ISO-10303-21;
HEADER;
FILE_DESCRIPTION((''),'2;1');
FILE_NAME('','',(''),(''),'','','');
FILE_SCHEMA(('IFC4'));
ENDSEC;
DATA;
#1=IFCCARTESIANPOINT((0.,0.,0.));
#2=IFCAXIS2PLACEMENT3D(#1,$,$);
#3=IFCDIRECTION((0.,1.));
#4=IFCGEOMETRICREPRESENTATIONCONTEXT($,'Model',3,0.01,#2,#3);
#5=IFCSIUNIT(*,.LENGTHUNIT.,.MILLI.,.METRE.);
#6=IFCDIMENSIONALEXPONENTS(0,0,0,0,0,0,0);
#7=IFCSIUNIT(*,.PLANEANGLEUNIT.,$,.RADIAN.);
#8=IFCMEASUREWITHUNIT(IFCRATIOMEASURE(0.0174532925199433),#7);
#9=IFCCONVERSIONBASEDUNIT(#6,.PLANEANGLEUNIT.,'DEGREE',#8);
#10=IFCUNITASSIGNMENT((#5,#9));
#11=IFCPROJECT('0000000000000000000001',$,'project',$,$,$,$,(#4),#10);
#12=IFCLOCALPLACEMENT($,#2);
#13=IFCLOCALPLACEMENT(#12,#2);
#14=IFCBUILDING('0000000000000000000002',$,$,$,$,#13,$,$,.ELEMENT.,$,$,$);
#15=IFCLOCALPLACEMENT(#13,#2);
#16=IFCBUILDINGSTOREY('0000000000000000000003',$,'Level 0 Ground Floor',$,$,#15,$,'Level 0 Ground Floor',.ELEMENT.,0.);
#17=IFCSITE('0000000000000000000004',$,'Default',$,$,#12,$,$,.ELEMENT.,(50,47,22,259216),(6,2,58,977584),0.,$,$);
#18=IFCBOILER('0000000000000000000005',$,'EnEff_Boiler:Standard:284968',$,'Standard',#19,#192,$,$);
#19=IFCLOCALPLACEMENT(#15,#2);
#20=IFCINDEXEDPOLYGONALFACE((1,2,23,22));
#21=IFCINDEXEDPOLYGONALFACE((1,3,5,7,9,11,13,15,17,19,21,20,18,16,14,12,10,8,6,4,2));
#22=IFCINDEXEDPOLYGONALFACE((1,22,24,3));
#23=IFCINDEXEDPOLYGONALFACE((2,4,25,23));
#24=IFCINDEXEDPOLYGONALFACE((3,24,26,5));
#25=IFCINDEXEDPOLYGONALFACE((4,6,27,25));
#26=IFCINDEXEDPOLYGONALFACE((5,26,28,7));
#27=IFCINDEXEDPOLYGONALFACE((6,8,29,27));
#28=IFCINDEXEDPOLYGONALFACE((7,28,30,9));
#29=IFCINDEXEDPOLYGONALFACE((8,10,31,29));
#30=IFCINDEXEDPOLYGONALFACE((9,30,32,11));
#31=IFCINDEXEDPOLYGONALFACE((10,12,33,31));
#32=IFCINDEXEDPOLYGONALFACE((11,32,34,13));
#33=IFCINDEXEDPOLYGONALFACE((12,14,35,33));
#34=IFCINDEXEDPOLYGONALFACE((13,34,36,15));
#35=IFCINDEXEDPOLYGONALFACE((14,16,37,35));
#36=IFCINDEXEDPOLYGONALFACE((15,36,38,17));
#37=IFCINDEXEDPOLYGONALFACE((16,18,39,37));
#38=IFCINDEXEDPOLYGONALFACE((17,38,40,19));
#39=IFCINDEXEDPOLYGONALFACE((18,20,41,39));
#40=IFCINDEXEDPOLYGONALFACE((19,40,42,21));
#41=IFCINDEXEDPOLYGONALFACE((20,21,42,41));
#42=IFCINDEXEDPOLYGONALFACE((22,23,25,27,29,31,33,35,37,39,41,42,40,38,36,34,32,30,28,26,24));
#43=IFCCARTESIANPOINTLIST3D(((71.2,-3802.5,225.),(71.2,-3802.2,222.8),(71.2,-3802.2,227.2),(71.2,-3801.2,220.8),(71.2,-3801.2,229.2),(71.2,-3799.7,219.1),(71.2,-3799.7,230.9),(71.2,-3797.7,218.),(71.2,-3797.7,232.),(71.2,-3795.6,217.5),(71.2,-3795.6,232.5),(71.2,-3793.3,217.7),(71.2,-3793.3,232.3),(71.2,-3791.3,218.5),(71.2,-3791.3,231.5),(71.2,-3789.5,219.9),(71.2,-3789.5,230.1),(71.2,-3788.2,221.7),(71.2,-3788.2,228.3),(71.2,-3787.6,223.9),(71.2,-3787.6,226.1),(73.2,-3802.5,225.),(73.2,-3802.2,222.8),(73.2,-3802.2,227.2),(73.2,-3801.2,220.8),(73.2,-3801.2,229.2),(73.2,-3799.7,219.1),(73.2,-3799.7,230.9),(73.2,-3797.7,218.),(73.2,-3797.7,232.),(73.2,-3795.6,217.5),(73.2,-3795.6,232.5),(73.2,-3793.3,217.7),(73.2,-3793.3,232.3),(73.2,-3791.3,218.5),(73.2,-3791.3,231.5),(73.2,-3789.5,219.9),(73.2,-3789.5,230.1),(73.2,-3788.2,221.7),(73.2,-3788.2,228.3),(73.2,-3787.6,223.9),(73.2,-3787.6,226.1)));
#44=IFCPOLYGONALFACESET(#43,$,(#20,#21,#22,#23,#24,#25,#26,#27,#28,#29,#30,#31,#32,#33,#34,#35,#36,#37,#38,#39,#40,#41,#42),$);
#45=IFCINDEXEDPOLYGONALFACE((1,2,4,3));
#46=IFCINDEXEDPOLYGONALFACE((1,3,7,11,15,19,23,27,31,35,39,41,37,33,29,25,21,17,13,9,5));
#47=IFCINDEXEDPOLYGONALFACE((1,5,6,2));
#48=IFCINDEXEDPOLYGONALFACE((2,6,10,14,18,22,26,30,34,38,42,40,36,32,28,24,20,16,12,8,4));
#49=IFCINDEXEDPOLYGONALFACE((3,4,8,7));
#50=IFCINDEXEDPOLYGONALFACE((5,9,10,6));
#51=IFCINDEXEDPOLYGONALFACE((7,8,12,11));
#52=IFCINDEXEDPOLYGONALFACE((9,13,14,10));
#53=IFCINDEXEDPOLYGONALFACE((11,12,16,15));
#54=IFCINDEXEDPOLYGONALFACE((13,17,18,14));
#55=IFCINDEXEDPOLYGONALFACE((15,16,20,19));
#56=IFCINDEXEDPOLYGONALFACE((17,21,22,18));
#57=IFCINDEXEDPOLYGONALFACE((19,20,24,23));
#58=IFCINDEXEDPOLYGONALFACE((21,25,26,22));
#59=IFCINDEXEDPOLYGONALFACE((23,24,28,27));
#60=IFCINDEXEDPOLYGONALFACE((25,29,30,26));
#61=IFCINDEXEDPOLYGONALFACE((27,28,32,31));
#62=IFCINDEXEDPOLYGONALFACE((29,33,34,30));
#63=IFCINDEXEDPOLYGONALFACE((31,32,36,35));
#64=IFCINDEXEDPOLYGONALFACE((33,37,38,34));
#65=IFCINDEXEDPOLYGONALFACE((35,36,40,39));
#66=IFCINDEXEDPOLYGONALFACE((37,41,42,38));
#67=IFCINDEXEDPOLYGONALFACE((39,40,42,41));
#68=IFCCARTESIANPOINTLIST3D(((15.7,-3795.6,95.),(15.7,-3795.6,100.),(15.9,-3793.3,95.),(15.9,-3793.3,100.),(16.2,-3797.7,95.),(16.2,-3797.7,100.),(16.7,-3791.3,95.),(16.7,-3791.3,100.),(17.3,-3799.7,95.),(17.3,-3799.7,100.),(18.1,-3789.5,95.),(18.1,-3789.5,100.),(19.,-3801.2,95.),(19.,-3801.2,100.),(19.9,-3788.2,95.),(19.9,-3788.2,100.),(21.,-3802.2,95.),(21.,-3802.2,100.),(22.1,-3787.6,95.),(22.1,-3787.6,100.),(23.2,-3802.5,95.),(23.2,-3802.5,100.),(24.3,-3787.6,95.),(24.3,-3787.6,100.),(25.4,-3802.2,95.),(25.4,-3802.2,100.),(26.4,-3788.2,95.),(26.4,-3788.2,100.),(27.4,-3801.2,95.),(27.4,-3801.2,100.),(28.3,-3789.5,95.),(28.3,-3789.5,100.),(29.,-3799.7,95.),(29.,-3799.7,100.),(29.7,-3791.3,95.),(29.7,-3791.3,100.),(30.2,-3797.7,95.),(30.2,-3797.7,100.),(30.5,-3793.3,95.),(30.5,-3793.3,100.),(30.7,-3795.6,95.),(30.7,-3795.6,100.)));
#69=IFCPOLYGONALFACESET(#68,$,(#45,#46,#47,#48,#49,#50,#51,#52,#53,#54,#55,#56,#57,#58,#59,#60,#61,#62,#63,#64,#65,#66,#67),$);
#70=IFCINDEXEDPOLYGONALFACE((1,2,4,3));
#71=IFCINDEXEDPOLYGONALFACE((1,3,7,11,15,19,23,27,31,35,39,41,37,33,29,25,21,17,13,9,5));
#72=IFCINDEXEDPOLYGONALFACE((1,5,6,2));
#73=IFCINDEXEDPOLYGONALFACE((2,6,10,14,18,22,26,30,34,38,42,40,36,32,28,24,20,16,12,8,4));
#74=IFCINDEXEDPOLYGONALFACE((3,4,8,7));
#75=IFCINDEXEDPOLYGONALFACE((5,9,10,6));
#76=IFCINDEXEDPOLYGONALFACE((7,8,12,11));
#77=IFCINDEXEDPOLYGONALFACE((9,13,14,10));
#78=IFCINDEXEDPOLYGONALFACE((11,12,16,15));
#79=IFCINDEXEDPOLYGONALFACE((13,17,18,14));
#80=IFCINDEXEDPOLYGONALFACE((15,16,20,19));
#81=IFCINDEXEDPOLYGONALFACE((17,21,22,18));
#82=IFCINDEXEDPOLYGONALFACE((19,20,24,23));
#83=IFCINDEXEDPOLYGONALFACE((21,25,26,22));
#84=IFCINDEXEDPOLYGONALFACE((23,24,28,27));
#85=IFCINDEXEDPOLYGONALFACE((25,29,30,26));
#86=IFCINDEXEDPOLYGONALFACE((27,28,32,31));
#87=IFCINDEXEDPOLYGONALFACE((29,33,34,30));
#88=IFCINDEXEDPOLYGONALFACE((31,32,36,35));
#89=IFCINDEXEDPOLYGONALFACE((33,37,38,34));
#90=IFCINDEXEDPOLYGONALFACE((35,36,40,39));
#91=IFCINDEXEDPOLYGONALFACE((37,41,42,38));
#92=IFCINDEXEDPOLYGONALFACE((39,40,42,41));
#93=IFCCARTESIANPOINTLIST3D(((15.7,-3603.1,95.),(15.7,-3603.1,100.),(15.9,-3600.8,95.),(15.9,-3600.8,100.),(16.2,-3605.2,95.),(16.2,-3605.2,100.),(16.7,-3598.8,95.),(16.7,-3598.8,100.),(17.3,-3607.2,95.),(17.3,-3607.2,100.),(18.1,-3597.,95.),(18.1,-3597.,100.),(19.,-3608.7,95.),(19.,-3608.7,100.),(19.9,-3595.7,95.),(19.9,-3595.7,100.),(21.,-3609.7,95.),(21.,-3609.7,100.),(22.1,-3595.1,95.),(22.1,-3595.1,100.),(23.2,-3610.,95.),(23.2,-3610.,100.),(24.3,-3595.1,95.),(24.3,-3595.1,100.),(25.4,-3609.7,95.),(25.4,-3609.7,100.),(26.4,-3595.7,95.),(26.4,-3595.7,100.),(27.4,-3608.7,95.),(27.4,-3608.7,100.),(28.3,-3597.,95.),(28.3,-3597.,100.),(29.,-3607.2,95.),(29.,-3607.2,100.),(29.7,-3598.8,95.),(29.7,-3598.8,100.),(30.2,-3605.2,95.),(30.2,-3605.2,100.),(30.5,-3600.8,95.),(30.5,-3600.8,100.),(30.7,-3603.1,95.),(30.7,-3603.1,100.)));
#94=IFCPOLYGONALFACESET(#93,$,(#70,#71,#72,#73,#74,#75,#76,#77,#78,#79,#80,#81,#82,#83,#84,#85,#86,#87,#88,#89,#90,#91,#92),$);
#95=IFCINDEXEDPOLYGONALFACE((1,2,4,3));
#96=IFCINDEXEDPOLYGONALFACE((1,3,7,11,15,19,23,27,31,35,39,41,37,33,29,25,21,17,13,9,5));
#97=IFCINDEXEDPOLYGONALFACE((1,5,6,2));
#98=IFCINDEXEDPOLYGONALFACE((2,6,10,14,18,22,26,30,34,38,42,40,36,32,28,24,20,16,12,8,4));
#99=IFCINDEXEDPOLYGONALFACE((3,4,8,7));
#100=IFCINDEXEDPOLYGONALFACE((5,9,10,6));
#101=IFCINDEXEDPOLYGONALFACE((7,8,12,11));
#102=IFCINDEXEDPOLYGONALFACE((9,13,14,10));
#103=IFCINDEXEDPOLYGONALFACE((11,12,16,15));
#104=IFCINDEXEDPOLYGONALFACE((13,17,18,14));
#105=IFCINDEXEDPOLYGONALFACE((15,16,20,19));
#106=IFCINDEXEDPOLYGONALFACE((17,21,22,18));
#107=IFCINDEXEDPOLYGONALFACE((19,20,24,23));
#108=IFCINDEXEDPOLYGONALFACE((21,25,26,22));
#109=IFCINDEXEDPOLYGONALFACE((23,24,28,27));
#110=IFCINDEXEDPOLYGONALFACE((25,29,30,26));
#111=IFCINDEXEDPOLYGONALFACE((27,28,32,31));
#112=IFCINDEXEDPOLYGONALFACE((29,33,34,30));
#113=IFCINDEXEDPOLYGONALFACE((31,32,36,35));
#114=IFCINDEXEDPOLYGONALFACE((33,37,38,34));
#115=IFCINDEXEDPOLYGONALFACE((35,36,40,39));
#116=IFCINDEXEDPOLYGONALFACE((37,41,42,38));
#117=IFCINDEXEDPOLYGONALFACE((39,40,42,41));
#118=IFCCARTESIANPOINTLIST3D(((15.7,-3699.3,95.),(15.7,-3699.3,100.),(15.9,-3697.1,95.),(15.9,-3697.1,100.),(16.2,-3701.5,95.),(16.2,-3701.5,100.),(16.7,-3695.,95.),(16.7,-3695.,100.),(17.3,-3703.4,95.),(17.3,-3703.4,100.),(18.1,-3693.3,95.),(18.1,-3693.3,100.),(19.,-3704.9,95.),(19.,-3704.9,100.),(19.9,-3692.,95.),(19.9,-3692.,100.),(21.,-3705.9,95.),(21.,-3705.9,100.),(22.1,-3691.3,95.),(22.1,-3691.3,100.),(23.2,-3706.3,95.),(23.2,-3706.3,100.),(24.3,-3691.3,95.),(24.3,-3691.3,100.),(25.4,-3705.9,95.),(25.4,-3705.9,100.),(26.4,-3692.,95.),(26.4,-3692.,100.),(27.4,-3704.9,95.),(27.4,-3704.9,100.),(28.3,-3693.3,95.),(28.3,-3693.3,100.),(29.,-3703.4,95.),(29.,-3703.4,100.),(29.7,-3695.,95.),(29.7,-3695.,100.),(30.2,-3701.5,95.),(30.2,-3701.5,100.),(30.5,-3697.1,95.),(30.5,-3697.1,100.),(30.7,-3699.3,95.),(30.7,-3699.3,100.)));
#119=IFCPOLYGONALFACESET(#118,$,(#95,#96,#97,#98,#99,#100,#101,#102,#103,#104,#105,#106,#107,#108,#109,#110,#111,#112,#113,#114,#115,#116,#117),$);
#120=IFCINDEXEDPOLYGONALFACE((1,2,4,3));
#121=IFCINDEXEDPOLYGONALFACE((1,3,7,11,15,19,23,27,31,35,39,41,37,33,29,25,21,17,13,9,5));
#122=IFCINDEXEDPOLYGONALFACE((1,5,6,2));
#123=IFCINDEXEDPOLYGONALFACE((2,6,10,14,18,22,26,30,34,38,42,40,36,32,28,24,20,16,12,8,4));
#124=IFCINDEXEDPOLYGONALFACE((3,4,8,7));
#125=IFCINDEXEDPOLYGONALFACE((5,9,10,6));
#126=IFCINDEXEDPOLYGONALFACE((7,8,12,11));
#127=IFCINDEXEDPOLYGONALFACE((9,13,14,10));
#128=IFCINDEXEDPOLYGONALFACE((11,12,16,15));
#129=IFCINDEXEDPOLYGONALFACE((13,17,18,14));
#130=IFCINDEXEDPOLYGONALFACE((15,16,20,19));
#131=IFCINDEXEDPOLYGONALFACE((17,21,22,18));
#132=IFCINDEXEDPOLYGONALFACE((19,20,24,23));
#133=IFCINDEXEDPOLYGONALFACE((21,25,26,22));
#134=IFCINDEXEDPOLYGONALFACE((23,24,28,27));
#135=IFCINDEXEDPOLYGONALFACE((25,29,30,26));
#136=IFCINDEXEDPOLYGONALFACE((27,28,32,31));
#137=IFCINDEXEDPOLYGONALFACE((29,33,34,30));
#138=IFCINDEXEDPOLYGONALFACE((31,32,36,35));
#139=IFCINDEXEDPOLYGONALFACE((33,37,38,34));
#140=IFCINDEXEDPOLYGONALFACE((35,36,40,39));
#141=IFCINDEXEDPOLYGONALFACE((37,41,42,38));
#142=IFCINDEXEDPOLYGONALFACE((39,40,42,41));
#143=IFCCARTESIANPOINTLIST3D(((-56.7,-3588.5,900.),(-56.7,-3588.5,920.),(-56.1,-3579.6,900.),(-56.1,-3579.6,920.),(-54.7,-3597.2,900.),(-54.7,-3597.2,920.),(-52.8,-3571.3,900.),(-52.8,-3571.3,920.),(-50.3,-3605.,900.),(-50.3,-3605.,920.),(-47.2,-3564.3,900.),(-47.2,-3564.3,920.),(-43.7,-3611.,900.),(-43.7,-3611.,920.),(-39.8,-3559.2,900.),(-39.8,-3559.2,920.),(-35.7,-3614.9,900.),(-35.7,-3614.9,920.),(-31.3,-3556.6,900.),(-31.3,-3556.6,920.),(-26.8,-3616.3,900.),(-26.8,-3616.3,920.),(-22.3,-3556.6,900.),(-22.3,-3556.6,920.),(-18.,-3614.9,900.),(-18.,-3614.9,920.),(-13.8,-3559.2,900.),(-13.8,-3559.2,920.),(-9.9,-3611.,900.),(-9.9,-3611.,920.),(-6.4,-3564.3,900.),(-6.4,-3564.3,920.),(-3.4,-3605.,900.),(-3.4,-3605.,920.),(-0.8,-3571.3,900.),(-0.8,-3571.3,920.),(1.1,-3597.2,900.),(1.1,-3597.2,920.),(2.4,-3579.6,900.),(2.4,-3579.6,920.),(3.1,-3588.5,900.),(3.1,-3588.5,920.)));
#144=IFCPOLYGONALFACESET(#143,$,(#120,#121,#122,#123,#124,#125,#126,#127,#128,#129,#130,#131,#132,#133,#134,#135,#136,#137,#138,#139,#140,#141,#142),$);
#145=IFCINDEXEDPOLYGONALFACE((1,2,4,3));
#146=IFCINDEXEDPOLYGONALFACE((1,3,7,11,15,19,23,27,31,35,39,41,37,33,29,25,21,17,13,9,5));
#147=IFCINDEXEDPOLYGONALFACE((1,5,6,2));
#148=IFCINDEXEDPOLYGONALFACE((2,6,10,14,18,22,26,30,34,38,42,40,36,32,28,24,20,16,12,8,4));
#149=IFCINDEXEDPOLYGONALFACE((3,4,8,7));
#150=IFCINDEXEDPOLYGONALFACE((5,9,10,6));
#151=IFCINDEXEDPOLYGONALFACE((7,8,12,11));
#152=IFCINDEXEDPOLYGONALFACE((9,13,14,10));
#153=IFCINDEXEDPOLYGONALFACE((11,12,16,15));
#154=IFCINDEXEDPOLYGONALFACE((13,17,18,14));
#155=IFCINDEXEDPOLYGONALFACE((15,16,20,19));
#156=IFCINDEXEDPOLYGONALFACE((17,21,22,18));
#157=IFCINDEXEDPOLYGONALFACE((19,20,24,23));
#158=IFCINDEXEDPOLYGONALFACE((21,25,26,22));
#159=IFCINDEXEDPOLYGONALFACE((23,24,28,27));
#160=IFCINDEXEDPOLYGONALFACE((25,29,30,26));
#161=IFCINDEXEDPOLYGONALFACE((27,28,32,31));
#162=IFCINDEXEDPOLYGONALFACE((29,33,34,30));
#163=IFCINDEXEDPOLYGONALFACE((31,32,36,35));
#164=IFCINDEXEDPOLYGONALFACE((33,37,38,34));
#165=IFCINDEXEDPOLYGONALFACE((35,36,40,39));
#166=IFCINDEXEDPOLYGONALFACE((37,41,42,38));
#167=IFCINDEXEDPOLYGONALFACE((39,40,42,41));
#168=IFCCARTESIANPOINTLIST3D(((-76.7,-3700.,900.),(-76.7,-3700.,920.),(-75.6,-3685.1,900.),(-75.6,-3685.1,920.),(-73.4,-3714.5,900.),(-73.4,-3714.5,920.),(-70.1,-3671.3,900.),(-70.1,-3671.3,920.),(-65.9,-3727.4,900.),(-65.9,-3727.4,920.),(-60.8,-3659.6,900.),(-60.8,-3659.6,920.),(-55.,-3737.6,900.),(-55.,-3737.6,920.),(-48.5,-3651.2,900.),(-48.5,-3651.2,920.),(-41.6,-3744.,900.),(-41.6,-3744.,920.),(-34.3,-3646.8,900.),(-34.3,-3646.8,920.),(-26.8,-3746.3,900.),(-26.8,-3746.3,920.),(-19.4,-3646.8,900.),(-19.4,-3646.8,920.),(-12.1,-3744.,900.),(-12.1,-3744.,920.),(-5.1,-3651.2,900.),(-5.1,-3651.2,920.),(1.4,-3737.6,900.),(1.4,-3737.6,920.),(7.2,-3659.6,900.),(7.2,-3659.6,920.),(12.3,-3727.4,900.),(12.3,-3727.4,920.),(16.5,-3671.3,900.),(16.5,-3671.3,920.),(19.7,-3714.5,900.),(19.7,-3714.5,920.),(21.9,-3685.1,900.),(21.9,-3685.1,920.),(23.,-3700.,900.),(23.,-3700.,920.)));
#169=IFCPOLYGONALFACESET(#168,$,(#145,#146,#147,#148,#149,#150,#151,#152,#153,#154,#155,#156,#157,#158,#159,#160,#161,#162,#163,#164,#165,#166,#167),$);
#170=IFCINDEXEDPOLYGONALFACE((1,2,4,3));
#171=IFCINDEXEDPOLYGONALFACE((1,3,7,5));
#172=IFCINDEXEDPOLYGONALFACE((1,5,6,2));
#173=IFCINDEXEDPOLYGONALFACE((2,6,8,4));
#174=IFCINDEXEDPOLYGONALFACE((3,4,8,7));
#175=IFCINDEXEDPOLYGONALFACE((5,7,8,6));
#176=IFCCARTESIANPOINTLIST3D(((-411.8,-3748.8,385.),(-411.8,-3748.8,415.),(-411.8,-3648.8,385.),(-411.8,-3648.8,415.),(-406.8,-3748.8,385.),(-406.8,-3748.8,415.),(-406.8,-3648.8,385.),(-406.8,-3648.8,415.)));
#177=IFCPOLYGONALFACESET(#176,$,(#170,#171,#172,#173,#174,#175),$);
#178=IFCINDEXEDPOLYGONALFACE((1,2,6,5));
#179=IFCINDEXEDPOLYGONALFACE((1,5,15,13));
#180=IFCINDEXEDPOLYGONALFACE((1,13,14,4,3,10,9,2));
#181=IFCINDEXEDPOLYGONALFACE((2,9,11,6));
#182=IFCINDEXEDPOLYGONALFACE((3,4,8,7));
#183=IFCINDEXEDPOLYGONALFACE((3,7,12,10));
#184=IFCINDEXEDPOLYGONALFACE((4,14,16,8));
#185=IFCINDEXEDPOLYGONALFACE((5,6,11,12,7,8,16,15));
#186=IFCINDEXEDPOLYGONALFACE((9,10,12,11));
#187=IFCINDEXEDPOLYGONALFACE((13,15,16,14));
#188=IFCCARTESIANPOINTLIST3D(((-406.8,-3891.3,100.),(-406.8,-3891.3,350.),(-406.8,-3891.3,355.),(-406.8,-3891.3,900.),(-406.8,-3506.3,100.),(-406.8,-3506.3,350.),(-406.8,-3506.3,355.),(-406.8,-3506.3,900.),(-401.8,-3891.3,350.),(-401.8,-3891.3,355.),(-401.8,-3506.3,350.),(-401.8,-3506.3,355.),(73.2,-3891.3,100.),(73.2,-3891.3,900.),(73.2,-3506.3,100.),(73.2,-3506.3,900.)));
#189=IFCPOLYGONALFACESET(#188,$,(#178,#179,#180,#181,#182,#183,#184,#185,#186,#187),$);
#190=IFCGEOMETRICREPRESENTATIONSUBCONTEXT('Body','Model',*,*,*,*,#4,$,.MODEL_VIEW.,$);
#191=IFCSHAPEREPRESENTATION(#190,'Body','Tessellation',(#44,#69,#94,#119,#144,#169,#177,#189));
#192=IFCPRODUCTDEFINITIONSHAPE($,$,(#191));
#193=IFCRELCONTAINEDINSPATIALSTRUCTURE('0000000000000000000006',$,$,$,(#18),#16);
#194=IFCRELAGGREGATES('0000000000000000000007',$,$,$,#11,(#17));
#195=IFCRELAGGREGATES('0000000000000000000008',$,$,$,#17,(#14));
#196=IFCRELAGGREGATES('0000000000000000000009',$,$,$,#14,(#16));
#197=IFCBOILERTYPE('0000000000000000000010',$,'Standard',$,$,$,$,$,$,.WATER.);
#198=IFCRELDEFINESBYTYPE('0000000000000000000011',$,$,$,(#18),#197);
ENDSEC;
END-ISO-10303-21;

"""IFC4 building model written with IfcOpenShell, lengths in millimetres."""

from ifc_helpers import new_model, entity, si_unit, converted_unit, direction, frame, frame_2d, origin, origin_2d_with_axis, place, context, subcontext, project, spatial, polyline, rectangle, circle, outline, extrude, source, transform, mapped, type_object, type_shapes, element, save


model = new_model("IFC4")

# Units and contexts
model_context = context("Model", 3, precision=0.01, world=origin(), true_north=direction((0.0, 1.0)))
body_context = subcontext(model_context, "Body", "Model", "MODEL_VIEW")
ifc_project = project(units=[si_unit("LENGTHUNIT", "METRE", prefix="MILLI"), converted_unit("PLANEANGLEUNIT", "DEGREE", entity("IfcRatioMeasure", 0.0174532925199433), si_unit("PLANEANGLEUNIT", "RADIAN"), dimensions=[0, 0, 0, 0, 0, 0, 0])], contexts=[model_context])

# Site, building, storey
site_placement = place(None, origin())
site = spatial("IfcSite", under=ifc_project, at=site_placement, Name="Default", CompositionType="ELEMENT", RefLatitude=(50, 47, 22, 259216), RefLongitude=(6, 2, 58, 977584), RefElevation=0.0)
building_placement = place(site_placement, origin())
building = spatial("IfcBuilding", under=site, at=building_placement, CompositionType="ELEMENT")
storey_placement = place(building_placement, origin())
storey = spatial("IfcBuildingStorey", under=building, at=storey_placement, Name="Level 0 Ground Floor", LongName="Level 0 Ground Floor", CompositionType="ELEMENT", Elevation=0.0)

# Boiler
boiler_type = type_object("IfcBoilerType", Name="Standard", PredefinedType="WATER")
shared_shape_1 = source(origin(), body_context, "Body", "SweptSolid", [
    extrude(circle(Radius=7.5, at=frame_2d((0.0, 0.0), x_axis=(1.0, 0.0))), frame((96.3, -2.0, 125.0), z_axis=(0.0, 1.0, 0.0), x_axis=(1.0, 0.0, 0.0)), (0.0, 0.0, 1.0), 2.0),
    extrude(circle(Radius=7.5, at=frame_2d((0.0, 0.0), x_axis=(1.0, 0.0))), frame((96.2, -50.0, -5.0)), (0.0, 0.0, 1.0), 5.0),
    extrude(circle(Radius=7.5, at=frame_2d((0.0, 0.0), x_axis=(1.0, 0.0))), frame((-96.3, -50.0, -5.0)), (0.0, 0.0, 1.0), 5.0),
    extrude(circle(Radius=7.5, at=frame_2d((0.0, 0.0), x_axis=(1.0, 0.0))), frame((0.0, -50.0, -5.0)), (0.0, 0.0, 1.0), 5.0),
    extrude(circle(Radius=30.0, at=frame_2d((0.0, 0.0), x_axis=(1.0, 0.0))), frame((-112.5, -100.0, 800.0)), (0.0, 0.0, 1.0), 20.0),
    extrude(circle(Radius=50.0, at=frame_2d((0.0, 0.0), x_axis=(1.0, 0.0))), frame((-2.5, -100.0, 800.0)), (0.0, 0.0, 1.0), 20.0),
    extrude(rectangle(XDim=5.0, YDim=100.0, at=origin_2d_with_axis()), frame((0.0, -482.5, 285.0), z_axis=(0.0, 0.0, 1.0), x_axis=(0.0, 1.0, 0.0)), (0.0, 0.0, 1.0), 30.0),
    extrude(outline(polyline([(-358.8, -473.8), (121.2, -473.8), (121.2, 71.2), (116.3, 71.2), (116.3, 76.3), (121.2, 76.3), (121.2, 326.2), (-358.8, 326.2), (-358.8, -473.8)])), frame((-192.5, -358.8, 326.2), z_axis=(1.0, 0.0, 0.0), x_axis=(0.0, -1.0, 0.0)), (0.0, 0.0, 1.0), 385.0),
])
type_shapes(boiler_type, [shared_shape_1])
boiler_placement = place(storey_placement, frame((73.2, -3698.8, 100.0), z_axis=(0.0, 0.0, 1.0), x_axis=(0.0, -1.0, 0.0)))
element("IfcBoiler", 1, at=boiler_placement, inside=storey, type_object=boiler_type, Name="EnEff_Boiler:Standard:284968", ObjectType="Standard", context=body_context, shape_type="MappedRepresentation", body=[
    mapped(shared_shape_1, transform((0.0, 0.0, 0.0), scale=1.0)),
])

save(model, "model.ifc")
